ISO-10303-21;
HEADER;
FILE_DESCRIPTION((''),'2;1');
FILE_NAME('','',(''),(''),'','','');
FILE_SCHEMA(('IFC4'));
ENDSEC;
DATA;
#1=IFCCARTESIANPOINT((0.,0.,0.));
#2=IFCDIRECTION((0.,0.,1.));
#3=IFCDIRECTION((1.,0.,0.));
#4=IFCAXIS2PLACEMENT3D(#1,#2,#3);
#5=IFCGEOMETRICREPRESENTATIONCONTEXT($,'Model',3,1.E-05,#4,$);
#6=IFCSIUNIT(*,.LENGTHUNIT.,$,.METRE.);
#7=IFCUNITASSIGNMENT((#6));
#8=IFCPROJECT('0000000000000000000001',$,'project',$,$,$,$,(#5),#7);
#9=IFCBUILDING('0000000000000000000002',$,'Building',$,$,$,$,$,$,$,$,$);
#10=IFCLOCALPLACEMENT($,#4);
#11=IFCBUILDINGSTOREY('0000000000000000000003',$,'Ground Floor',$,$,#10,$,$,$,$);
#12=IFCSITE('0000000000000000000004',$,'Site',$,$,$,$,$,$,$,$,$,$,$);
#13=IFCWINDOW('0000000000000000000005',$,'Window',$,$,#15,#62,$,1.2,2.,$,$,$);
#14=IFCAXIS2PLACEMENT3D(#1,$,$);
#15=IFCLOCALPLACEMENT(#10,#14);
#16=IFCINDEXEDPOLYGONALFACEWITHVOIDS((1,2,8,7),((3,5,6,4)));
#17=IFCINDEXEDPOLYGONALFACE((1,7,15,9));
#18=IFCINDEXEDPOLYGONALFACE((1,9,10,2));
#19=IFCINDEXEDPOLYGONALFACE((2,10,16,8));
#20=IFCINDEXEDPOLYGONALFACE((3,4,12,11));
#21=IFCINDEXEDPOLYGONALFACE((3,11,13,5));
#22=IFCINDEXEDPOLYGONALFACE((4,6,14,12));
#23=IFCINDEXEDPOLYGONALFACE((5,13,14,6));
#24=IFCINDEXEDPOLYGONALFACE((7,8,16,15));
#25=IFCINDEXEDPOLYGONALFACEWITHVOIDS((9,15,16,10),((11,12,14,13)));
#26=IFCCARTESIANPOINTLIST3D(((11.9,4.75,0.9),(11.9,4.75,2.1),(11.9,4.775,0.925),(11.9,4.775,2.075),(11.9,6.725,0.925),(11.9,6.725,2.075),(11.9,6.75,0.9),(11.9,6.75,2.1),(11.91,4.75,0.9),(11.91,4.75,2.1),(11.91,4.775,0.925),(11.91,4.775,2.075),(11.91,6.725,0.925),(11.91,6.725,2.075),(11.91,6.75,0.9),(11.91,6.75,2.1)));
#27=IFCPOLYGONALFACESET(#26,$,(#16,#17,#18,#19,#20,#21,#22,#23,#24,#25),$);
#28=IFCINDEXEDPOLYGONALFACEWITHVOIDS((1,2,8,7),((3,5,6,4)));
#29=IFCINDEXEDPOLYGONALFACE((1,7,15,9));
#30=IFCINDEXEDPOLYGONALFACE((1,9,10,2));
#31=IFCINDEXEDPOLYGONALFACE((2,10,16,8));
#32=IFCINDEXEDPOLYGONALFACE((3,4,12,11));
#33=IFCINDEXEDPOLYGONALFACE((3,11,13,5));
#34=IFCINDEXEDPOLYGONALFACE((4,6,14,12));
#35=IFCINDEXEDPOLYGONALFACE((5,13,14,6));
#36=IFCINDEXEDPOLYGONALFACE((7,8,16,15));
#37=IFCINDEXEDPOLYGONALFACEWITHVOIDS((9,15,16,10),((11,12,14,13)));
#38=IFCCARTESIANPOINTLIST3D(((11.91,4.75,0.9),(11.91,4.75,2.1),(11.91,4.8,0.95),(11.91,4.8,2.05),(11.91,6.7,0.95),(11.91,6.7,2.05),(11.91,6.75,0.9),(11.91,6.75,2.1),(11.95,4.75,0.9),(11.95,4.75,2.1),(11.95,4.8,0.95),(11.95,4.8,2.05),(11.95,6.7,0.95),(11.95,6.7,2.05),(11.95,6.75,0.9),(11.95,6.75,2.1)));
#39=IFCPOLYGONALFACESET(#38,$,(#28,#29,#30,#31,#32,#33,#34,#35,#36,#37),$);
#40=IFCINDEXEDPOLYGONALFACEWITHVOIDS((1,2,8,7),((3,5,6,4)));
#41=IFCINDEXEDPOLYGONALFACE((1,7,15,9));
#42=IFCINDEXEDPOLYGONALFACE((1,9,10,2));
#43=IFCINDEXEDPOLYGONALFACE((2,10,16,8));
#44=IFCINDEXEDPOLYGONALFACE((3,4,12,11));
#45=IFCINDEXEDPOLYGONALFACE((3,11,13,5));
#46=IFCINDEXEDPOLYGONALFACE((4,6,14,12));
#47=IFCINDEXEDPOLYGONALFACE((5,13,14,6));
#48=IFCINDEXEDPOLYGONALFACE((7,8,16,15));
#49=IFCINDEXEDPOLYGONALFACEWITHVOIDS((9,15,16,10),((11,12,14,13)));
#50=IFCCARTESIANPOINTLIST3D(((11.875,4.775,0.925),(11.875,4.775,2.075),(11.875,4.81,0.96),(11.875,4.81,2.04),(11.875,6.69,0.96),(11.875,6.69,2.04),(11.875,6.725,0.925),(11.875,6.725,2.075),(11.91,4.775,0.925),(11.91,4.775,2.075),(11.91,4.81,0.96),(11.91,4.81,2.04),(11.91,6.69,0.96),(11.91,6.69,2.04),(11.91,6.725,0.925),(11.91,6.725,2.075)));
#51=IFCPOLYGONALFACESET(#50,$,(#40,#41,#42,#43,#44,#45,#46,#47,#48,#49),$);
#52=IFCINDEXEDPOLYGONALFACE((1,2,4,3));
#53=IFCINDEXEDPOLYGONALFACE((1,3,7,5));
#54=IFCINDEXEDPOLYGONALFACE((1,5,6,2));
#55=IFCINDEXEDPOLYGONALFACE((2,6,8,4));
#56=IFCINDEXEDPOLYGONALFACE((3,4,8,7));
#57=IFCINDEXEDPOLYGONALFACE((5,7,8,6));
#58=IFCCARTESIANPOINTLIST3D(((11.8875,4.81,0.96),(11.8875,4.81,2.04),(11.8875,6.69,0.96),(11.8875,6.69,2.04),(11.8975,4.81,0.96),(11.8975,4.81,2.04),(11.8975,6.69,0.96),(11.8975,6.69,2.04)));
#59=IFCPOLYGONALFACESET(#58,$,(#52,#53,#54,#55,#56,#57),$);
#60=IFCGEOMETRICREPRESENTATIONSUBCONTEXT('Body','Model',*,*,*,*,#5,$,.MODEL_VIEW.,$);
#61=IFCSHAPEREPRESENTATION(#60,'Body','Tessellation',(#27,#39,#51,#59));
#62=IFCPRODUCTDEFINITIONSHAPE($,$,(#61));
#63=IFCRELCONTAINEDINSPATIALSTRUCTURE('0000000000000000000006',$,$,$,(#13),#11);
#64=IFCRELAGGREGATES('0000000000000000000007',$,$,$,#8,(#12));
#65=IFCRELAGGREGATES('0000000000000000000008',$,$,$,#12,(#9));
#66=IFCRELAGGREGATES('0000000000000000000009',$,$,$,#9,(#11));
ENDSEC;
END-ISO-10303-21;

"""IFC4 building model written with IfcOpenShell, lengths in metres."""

from ifc_helpers import new_model, si_unit, frame, origin_with_axes, place, context, subcontext, project, spatial, line, indexed_curve, outline, extrude, element, save


model = new_model("IFC4")

# Units and contexts
model_context = context("Model", 3, precision=1e-05, world=origin_with_axes())
body_context = subcontext(model_context, "Body", "Model", "MODEL_VIEW")
ifc_project = project(units=[si_unit("LENGTHUNIT", "METRE")], contexts=[model_context])

# Site, building, storey
site = spatial("IfcSite", under=ifc_project, Name="Site")
building = spatial("IfcBuilding", under=site, Name="Building")
storey_placement = place(None, origin_with_axes())
storey = spatial("IfcBuildingStorey", under=building, at=storey_placement, Name="Ground Floor")

# Window
window_1_placement = place(storey_placement, frame((12.0, 4.75, 0.9), z_axis=(0.0, 0.0, 1.0), x_axis=(0.0, 1.0, 0.0)))
element("IfcWindow", 1, at=window_1_placement, inside=storey, Name="Window", OverallHeight=1.2, OverallWidth=2.0, context=body_context, shape_type="SweptSolid", body=[
    extrude(outline(indexed_curve([(0.0, 0.0), (2.0, 0.0), (2.0, 1.2), (0.0, 1.2)], segments=[line(1, 2, 3, 4, 1)]), holes=[indexed_curve([(0.025, 0.025), (1.975, 0.025), (1.975, 1.175), (0.025, 1.175)], segments=[line(1, 2, 3, 4, 1)])]), frame((0.0, 0.09, 0.0), z_axis=(0.0, -1.0, 0.0), x_axis=(1.0, 0.0, 0.0)), (0.0, 0.0, -1.0), 0.01),
    extrude(outline(indexed_curve([(0.0, 0.0), (2.0, 0.0), (2.0, 1.2), (0.0, 1.2)], segments=[line(1, 2, 3, 4, 1)]), holes=[indexed_curve([(0.05, 0.05), (1.95, 0.05), (1.95, 1.15), (0.05, 1.15)], segments=[line(1, 2, 3, 4, 1)])]), frame((0.0, 0.05, 0.0), z_axis=(0.0, -1.0, 0.0), x_axis=(1.0, 0.0, 0.0)), (0.0, 0.0, -1.0), 0.04),
    extrude(outline(indexed_curve([(0.0, 0.0), (1.95, 0.0), (1.95, 1.15), (0.0, 1.15)], segments=[line(1, 2, 3, 4, 1)]), holes=[indexed_curve([(0.035, 0.035), (1.915, 0.035), (1.915, 1.115), (0.035, 1.115)], segments=[line(1, 2, 3, 4, 1)])]), frame((0.025, 0.09, 0.025), z_axis=(0.0, -1.0, 0.0), x_axis=(1.0, 0.0, 0.0)), (0.0, 0.0, -1.0), 0.035),
    extrude(outline(indexed_curve([(0.035, 0.035), (1.915, 0.035), (1.915, 1.115), (0.035, 1.115)], segments=[line(1, 2, 3, 4, 1)])), frame((0.025, 0.1025, 0.025), z_axis=(0.0, -1.0, 0.0), x_axis=(1.0, 0.0, 0.0)), (0.0, 0.0, -1.0), 0.01),
])

save(model, "model.ifc")
